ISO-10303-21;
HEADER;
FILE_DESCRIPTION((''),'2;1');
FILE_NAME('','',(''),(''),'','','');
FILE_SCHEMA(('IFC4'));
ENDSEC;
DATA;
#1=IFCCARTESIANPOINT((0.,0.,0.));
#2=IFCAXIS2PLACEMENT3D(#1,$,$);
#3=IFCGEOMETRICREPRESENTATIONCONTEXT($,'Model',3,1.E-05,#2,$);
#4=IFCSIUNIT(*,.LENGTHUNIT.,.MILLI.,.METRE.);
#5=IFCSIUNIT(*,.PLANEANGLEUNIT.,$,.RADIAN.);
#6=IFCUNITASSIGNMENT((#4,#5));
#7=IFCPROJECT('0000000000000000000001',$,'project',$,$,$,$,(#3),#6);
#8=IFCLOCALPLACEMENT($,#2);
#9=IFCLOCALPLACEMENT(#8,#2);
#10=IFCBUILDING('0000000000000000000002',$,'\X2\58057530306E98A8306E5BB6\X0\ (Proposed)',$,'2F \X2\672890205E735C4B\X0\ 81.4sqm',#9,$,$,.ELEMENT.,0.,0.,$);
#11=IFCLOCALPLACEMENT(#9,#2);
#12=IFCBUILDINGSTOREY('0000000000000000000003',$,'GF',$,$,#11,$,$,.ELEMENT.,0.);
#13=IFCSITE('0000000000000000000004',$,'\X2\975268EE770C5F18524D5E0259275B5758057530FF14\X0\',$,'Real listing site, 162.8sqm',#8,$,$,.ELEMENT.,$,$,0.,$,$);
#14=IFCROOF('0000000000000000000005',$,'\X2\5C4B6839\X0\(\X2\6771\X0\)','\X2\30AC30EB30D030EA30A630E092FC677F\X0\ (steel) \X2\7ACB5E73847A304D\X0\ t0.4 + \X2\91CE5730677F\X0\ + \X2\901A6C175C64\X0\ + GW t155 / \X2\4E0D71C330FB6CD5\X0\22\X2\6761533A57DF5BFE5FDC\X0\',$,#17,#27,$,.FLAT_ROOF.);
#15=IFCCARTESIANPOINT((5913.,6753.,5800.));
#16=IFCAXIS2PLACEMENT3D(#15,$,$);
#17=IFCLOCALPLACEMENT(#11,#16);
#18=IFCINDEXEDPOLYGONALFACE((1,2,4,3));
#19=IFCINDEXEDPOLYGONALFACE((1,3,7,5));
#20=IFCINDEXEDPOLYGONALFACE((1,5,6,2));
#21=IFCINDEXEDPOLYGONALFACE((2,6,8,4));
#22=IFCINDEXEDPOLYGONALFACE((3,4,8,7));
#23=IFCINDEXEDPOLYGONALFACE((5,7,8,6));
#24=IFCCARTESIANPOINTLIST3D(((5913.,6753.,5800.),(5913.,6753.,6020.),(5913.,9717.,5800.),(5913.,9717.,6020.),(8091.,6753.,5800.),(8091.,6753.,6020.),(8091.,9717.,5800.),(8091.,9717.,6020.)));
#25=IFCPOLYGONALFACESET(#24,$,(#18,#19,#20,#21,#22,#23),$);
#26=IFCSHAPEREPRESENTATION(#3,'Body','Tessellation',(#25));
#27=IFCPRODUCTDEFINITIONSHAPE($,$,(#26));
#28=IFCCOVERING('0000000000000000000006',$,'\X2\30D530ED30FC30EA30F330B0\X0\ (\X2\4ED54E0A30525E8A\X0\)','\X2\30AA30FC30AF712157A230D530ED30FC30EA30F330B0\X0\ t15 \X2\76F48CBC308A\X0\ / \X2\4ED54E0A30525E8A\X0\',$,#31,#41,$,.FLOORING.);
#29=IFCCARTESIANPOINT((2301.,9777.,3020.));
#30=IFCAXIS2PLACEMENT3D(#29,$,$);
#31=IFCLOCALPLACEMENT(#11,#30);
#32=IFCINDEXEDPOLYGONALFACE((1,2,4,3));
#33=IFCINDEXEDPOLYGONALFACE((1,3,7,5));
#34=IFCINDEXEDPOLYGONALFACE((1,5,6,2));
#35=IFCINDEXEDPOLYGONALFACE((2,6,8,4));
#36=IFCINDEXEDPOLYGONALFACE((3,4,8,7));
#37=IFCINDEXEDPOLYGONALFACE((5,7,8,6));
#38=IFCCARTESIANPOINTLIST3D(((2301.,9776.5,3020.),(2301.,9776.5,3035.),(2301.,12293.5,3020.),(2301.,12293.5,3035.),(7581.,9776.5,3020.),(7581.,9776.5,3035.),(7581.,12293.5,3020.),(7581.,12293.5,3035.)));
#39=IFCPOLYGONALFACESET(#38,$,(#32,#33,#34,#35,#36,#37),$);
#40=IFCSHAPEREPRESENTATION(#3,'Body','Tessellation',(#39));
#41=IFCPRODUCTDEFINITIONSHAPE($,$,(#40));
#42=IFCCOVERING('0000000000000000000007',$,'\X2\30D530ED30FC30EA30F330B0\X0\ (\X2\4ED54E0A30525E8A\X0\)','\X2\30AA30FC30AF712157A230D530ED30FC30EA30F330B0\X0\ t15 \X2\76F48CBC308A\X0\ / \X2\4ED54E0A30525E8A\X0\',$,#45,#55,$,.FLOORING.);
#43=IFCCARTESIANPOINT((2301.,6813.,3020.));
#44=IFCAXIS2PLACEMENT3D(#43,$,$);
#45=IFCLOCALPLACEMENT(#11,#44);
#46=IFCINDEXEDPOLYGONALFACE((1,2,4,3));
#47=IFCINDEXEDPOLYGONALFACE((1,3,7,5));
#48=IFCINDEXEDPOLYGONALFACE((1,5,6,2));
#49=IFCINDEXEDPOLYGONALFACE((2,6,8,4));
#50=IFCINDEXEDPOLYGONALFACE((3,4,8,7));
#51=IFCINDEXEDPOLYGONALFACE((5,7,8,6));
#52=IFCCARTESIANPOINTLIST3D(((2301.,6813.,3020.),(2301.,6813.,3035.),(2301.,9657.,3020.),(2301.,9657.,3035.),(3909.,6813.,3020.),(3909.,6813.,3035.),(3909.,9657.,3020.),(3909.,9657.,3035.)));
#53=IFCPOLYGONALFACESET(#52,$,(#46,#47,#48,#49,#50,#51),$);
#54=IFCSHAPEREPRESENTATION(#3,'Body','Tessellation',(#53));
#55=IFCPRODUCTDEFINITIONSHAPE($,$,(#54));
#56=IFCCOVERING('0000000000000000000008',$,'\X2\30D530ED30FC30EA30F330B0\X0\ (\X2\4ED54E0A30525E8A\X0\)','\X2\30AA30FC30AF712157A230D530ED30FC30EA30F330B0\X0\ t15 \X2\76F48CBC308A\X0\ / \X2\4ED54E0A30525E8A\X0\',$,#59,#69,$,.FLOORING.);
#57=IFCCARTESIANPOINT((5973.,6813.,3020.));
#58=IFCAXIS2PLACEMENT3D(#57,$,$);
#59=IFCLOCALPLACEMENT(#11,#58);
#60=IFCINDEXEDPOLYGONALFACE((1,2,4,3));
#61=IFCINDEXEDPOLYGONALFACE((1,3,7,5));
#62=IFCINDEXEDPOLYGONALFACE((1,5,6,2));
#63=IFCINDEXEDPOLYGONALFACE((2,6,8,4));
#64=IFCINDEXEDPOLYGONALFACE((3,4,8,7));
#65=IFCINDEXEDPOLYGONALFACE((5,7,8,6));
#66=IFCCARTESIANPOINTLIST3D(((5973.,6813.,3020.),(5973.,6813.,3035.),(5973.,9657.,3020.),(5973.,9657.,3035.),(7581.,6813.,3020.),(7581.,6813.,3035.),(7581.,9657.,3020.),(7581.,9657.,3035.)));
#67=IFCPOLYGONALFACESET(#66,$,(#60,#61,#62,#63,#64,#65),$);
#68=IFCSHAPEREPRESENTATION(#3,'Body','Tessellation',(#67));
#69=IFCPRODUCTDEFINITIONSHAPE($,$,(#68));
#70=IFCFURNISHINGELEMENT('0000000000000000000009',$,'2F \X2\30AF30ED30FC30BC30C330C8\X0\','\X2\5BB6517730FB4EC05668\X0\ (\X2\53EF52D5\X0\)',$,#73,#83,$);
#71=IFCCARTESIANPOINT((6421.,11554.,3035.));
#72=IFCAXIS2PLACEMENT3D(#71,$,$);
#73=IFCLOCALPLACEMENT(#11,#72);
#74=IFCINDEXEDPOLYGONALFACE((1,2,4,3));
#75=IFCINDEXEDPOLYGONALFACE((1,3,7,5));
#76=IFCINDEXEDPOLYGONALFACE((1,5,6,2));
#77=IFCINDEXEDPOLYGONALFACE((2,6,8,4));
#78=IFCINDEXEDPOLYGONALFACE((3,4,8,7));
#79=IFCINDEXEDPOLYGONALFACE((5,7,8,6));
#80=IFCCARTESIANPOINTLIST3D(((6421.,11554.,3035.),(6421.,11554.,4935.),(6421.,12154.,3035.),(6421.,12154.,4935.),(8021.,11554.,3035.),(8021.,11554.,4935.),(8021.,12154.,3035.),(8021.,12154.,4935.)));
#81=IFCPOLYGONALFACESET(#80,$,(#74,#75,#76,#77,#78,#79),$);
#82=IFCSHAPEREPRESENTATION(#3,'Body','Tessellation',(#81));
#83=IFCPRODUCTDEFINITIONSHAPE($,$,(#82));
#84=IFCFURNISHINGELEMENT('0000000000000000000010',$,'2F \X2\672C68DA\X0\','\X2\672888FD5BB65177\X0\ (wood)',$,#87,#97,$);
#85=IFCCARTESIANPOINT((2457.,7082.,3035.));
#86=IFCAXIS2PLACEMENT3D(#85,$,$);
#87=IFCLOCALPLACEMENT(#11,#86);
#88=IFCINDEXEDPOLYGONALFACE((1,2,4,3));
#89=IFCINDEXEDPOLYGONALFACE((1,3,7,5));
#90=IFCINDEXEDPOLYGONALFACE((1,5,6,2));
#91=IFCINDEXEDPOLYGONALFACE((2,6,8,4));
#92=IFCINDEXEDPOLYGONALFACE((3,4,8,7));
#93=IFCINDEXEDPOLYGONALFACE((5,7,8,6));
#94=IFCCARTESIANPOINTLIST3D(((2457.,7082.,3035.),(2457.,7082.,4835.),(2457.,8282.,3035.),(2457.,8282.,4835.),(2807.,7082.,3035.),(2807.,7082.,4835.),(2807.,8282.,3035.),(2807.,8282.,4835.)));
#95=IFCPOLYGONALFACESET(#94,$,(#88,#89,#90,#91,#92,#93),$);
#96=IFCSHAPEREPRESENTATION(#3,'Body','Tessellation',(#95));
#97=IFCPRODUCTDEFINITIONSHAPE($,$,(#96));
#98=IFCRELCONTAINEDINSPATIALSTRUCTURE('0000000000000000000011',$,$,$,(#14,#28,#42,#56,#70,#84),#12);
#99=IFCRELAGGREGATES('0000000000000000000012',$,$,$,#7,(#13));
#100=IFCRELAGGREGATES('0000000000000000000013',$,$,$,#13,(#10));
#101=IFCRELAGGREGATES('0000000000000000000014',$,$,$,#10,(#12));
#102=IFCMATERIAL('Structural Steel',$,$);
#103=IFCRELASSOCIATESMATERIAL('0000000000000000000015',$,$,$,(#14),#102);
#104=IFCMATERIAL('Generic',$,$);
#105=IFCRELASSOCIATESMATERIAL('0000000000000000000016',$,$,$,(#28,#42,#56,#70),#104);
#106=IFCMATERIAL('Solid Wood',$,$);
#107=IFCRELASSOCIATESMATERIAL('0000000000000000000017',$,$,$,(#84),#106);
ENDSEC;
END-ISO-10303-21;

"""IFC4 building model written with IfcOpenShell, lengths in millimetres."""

from ifc_helpers import new_model, si_unit, frame, frame_2d, origin, place, context, project, spatial, rectangle, extrude, material, element, save


model = new_model("IFC4")

# Units and contexts
model_context = context("Model", 3, precision=1e-05, world=origin())
ifc_project = project(units=[si_unit("LENGTHUNIT", "METRE", prefix="MILLI"), si_unit("PLANEANGLEUNIT", "RADIAN")], contexts=[model_context])

# Site, building, storey
site_placement = place(None, origin())
site = spatial("IfcSite", under=ifc_project, at=site_placement, Name="青森県弘前市大字堅田４", ObjectType="Real listing site, 162.8sqm", CompositionType="ELEMENT", RefElevation=0.0)
building_placement = place(site_placement, origin())
building = spatial("IfcBuilding", under=site, at=building_placement, Name="堅田の風の家 (Proposed)", ObjectType="2F 木造平屋 81.4sqm", CompositionType="ELEMENT", ElevationOfRefHeight=0.0, ElevationOfTerrain=0.0)
storey_placement = place(building_placement, origin())
storey = spatial("IfcBuildingStorey", under=building, at=storey_placement, Name="GF", CompositionType="ELEMENT", Elevation=0.0)

# Shared definitions
ifc_material_1 = material(Name="Solid Wood")

# Roof
ifc_material_2 = material(Name="Structural Steel")
roof_1_placement = place(storey_placement, frame((5913.0, 6753.0, 5800.0)))
element("IfcRoof", 1, at=roof_1_placement, inside=storey, material=ifc_material_2, Name="屋根(東)", Description="ガルバリウム鋼板 (steel) 立平葺き t0.4 + 野地板 + 通気層 + GW t155 / 不燃・法22条区域対応", PredefinedType="FLAT_ROOF", context=model_context, shape_type="SweptSolid", body=[
    extrude(rectangle(XDim=2178.0, YDim=2964.0, at=frame_2d((1089.0, 1482.0))), frame((5913.0, 6753.0, 5800.0)), (0.0, 0.0, 1.0), 220.0),
])

# Coverings
ifc_material_3 = material(Name="Generic")
covering_1_placement = place(storey_placement, frame((2301.0, 9777.0, 3020.0)))
element("IfcCovering", 2, at=covering_1_placement, inside=storey, material=ifc_material_3, Name="フローリング (仕上げ床)", Description="オーク無垢フローリング t15 直貼り / 仕上げ床", PredefinedType="FLOORING", context=model_context, shape_type="SweptSolid", body=[
    extrude(rectangle(XDim=5280.0, YDim=2517.0, at=frame_2d((2640.0, 1258.0))), frame((2301.0, 9777.0, 3020.0)), (0.0, 0.0, 1.0), 15.0),
])
covering_2_placement = place(storey_placement, frame((2301.0, 6813.0, 3020.0)))
element("IfcCovering", 3, at=covering_2_placement, inside=storey, material=ifc_material_3, Name="フローリング (仕上げ床)", Description="オーク無垢フローリング t15 直貼り / 仕上げ床", PredefinedType="FLOORING", context=model_context, shape_type="SweptSolid", body=[
    extrude(rectangle(XDim=1608.0, YDim=2844.0, at=frame_2d((804.0, 1422.0))), frame((2301.0, 6813.0, 3020.0)), (0.0, 0.0, 1.0), 15.0),
])
covering_3_placement = place(storey_placement, frame((5973.0, 6813.0, 3020.0)))
element("IfcCovering", 4, at=covering_3_placement, inside=storey, material=ifc_material_3, Name="フローリング (仕上げ床)", Description="オーク無垢フローリング t15 直貼り / 仕上げ床", PredefinedType="FLOORING", context=model_context, shape_type="SweptSolid", body=[
    extrude(rectangle(XDim=1608.0, YDim=2844.0, at=frame_2d((804.0, 1422.0))), frame((5973.0, 6813.0, 3020.0)), (0.0, 0.0, 1.0), 15.0),
])

# Furnishing elements
furnishing_1_placement = place(storey_placement, frame((6421.0, 11554.0, 3035.0)))
element("IfcFurnishingElement", 5, at=furnishing_1_placement, inside=storey, material=ifc_material_3, Name="2F クローゼット", Description="家具・什器 (可動)", context=model_context, shape_type="SweptSolid", body=[
    extrude(rectangle(XDim=1600.0, YDim=600.0, at=frame_2d((800.0, 300.0))), frame((6421.0, 11554.0, 3035.0)), (0.0, 0.0, 1.0), 1900.0),
])
furnishing_2_placement = place(storey_placement, frame((2457.0, 7082.0, 3035.0)))
element("IfcFurnishingElement", 6, at=furnishing_2_placement, inside=storey, material=ifc_material_1, Name="2F 本棚", Description="木製家具 (wood)", context=model_context, shape_type="SweptSolid", body=[
    extrude(rectangle(XDim=350.0, YDim=1200.0, at=frame_2d((175.0, 600.0))), frame((2457.0, 7082.0, 3035.0)), (0.0, 0.0, 1.0), 1800.0),
])

save(model, "model.ifc")
